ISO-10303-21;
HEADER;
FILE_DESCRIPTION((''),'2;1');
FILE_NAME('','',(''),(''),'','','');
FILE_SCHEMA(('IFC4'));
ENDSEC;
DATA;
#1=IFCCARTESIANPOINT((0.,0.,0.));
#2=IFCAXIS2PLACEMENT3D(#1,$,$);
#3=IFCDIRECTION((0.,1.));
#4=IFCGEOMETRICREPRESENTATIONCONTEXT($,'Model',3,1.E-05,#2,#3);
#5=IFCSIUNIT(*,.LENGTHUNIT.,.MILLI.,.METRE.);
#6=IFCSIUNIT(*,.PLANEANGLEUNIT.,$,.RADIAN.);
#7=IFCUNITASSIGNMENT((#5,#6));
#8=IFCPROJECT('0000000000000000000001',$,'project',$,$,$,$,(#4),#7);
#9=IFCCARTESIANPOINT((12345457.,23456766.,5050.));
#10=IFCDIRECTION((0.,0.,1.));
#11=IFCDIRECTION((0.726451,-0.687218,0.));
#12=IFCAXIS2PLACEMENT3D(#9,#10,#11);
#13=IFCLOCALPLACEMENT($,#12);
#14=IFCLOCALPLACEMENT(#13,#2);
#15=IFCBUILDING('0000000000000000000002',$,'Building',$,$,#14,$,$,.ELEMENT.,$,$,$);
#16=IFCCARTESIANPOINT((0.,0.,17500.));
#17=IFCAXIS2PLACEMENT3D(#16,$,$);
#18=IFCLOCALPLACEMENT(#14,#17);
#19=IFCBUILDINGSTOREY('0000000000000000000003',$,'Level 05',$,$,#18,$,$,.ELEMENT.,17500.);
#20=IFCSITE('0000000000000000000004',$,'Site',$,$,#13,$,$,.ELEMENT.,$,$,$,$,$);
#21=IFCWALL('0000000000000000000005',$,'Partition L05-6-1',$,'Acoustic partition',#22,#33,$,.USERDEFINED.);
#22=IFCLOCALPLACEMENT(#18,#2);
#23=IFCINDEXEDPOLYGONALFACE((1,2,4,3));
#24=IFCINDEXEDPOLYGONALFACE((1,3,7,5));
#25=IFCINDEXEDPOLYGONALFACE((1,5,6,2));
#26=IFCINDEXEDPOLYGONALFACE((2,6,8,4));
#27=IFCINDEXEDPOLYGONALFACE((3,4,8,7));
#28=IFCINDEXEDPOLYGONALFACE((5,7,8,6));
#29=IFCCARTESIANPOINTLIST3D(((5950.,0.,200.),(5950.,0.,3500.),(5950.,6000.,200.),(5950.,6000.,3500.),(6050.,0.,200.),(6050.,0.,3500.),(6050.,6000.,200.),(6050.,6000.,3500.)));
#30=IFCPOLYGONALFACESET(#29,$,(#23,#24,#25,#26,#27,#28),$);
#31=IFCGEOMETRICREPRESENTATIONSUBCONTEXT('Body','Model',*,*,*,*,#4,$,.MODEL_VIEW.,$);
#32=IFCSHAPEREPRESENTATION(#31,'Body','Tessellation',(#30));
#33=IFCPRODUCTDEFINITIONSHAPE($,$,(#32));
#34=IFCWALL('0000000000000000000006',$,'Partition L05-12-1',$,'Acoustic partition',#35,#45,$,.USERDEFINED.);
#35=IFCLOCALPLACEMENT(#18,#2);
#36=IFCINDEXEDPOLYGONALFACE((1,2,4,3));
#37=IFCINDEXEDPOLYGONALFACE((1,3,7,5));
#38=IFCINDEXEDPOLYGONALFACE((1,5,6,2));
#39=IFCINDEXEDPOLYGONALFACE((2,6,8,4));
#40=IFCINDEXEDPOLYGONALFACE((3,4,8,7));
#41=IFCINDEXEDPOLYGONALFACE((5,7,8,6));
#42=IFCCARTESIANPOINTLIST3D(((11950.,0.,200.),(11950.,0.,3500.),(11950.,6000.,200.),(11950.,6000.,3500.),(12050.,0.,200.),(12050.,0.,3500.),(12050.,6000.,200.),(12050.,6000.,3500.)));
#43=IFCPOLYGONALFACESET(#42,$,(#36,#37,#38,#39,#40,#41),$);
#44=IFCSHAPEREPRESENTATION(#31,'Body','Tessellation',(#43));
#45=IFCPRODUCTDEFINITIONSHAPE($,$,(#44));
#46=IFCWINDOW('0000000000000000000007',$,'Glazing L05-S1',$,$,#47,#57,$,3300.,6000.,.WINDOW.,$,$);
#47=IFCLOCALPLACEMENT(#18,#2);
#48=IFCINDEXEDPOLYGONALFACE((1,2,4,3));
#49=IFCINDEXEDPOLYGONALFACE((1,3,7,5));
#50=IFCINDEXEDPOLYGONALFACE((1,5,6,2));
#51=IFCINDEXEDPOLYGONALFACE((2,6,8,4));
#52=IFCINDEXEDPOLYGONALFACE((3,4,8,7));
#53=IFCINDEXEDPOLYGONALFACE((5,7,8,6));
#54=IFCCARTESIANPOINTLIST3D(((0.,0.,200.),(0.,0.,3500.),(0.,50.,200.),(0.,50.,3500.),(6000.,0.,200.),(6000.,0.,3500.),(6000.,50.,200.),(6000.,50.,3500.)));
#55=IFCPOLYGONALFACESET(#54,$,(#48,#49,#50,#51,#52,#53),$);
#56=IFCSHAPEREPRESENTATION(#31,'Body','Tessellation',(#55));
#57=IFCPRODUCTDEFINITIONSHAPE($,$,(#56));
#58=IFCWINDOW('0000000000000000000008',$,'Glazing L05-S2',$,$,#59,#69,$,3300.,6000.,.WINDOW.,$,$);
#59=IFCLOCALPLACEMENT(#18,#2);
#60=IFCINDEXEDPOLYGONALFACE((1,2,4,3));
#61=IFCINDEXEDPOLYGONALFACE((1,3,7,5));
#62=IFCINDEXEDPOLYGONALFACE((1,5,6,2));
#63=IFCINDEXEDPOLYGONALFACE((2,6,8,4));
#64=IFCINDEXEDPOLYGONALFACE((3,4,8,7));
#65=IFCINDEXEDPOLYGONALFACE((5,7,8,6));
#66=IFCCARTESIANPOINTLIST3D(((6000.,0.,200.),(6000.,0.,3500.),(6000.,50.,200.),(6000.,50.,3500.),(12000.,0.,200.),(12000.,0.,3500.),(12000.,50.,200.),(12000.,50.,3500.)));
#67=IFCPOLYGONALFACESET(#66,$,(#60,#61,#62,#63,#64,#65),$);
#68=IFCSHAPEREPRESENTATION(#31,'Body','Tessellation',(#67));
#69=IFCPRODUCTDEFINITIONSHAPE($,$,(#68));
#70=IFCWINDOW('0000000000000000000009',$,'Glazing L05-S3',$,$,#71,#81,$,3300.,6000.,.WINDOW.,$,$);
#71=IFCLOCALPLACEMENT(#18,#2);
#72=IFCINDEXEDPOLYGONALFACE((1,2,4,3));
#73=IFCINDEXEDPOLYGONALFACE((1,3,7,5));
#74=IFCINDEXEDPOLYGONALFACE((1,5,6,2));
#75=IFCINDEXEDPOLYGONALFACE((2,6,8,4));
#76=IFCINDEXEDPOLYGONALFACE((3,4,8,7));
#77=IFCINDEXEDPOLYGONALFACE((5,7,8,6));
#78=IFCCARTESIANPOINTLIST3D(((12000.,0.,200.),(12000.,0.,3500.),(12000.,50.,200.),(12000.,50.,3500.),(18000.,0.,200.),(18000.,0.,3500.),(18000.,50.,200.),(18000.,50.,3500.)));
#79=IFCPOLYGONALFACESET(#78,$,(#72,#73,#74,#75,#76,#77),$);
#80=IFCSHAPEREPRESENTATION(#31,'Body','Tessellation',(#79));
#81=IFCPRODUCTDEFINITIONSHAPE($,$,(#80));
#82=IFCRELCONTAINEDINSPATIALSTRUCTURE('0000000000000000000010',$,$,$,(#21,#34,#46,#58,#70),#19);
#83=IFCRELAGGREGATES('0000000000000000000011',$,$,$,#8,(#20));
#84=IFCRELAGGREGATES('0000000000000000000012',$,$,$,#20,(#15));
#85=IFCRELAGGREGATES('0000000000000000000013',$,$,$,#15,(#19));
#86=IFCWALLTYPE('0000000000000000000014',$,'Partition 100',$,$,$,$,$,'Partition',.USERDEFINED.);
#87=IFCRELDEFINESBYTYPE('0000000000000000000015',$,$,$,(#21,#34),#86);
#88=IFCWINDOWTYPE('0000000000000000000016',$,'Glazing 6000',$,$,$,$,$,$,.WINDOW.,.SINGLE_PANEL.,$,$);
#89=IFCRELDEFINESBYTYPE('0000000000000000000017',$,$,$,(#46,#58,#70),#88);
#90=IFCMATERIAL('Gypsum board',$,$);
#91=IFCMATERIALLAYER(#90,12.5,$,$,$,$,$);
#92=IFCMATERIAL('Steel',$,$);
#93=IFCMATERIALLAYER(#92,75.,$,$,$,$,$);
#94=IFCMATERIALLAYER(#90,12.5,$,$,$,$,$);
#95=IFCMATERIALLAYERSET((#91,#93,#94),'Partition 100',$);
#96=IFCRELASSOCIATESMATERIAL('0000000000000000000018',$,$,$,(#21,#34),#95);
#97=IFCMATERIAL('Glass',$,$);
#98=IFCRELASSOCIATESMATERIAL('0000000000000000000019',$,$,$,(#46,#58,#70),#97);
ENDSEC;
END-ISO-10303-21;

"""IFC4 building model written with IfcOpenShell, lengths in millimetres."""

from ifc_helpers import new_model, si_unit, direction, frame, origin, place, context, subcontext, project, spatial, rectangle, extrude, material, layer, layer_set, layer_usage, type_object, element, save


model = new_model("IFC4")

# Units and contexts
model_context = context("Model", 3, precision=1e-05, world=origin(), true_north=direction((0.0, 1.0)))
body_context = subcontext(model_context, "Body", "Model", "MODEL_VIEW")
ifc_project = project(units=[si_unit("LENGTHUNIT", "METRE", prefix="MILLI"), si_unit("PLANEANGLEUNIT", "RADIAN")], contexts=[model_context])

# Site, building, storey
site_placement = place(None, frame((12345457.0, 23456766.0, 5050.0), z_axis=(0.0, 0.0, 1.0), x_axis=(0.726451, -0.687218, 0.0)))
site = spatial("IfcSite", under=ifc_project, at=site_placement, Name="Site", CompositionType="ELEMENT")
building_placement = place(site_placement, origin())
building = spatial("IfcBuilding", under=site, at=building_placement, Name="Building", CompositionType="ELEMENT")
storey_placement = place(building_placement, frame((0.0, 0.0, 17500.0)))
storey = spatial("IfcBuildingStorey", under=building, at=storey_placement, Name="Level 05", CompositionType="ELEMENT", Elevation=17500.0)

# Shared definitions
ifc_material_1 = material(Name="Steel")

# Walls
ifc_material_2 = material(Name="Gypsum board")
ifc_layer_1 = layer(ifc_material_2, 12.5)
ifc_layer_2 = layer(ifc_material_1, 75.0)
ifc_layer_3 = layer(ifc_material_2, 12.5)
ifc_layer_set_1 = layer_set([ifc_layer_1, ifc_layer_2, ifc_layer_3], Name="Partition 100")
ifc_layer_usage_1 = layer_usage(ifc_layer_set_1, "AXIS2", "POSITIVE", 0.0)
wall_type_1 = type_object("IfcWallType", Name="Partition 100", ElementType="Partition", PredefinedType="USERDEFINED")
for number, where, name in (
    (1, (5950.0, 0.0, 200.0), "Partition L05-6-1"),
    (2, (11950.0, 0.0, 200.0), "Partition L05-12-1"),
):
    element("IfcWall", number, at=place(storey_placement, frame(where)), inside=storey, type_object=wall_type_1, material=ifc_layer_usage_1, Name=name, ObjectType="Acoustic partition", PredefinedType="USERDEFINED", context=body_context, shape_type="SweptSolid", body=[
        extrude(rectangle(XDim=100.0, YDim=6000.0), frame((50.0, 3000.0, 0.0)), (0.0, 0.0, 1.0), 3300.0),
    ])

# Windows
ifc_material_3 = material(Name="Glass")
window_type = type_object("IfcWindowType", Name="Glazing 6000", PartitioningType="SINGLE_PANEL", PredefinedType="WINDOW")
for number, where, name in (
    (3, (0.0, 0.0, 200.0), "Glazing L05-S1"),
    (4, (6000.0, 0.0, 200.0), "Glazing L05-S2"),
    (5, (12000.0, 0.0, 200.0), "Glazing L05-S3"),
):
    element("IfcWindow", number, at=place(storey_placement, frame(where)), inside=storey, type_object=window_type, material=ifc_material_3, Name=name, OverallHeight=3300.0, OverallWidth=6000.0, PredefinedType="WINDOW", context=body_context, shape_type="SweptSolid", body=[
        extrude(rectangle(XDim=6000.0, YDim=50.0), frame((3000.0, 25.0, 0.0)), (0.0, 0.0, 1.0), 3300.0),
    ])

save(model, "model.ifc")
